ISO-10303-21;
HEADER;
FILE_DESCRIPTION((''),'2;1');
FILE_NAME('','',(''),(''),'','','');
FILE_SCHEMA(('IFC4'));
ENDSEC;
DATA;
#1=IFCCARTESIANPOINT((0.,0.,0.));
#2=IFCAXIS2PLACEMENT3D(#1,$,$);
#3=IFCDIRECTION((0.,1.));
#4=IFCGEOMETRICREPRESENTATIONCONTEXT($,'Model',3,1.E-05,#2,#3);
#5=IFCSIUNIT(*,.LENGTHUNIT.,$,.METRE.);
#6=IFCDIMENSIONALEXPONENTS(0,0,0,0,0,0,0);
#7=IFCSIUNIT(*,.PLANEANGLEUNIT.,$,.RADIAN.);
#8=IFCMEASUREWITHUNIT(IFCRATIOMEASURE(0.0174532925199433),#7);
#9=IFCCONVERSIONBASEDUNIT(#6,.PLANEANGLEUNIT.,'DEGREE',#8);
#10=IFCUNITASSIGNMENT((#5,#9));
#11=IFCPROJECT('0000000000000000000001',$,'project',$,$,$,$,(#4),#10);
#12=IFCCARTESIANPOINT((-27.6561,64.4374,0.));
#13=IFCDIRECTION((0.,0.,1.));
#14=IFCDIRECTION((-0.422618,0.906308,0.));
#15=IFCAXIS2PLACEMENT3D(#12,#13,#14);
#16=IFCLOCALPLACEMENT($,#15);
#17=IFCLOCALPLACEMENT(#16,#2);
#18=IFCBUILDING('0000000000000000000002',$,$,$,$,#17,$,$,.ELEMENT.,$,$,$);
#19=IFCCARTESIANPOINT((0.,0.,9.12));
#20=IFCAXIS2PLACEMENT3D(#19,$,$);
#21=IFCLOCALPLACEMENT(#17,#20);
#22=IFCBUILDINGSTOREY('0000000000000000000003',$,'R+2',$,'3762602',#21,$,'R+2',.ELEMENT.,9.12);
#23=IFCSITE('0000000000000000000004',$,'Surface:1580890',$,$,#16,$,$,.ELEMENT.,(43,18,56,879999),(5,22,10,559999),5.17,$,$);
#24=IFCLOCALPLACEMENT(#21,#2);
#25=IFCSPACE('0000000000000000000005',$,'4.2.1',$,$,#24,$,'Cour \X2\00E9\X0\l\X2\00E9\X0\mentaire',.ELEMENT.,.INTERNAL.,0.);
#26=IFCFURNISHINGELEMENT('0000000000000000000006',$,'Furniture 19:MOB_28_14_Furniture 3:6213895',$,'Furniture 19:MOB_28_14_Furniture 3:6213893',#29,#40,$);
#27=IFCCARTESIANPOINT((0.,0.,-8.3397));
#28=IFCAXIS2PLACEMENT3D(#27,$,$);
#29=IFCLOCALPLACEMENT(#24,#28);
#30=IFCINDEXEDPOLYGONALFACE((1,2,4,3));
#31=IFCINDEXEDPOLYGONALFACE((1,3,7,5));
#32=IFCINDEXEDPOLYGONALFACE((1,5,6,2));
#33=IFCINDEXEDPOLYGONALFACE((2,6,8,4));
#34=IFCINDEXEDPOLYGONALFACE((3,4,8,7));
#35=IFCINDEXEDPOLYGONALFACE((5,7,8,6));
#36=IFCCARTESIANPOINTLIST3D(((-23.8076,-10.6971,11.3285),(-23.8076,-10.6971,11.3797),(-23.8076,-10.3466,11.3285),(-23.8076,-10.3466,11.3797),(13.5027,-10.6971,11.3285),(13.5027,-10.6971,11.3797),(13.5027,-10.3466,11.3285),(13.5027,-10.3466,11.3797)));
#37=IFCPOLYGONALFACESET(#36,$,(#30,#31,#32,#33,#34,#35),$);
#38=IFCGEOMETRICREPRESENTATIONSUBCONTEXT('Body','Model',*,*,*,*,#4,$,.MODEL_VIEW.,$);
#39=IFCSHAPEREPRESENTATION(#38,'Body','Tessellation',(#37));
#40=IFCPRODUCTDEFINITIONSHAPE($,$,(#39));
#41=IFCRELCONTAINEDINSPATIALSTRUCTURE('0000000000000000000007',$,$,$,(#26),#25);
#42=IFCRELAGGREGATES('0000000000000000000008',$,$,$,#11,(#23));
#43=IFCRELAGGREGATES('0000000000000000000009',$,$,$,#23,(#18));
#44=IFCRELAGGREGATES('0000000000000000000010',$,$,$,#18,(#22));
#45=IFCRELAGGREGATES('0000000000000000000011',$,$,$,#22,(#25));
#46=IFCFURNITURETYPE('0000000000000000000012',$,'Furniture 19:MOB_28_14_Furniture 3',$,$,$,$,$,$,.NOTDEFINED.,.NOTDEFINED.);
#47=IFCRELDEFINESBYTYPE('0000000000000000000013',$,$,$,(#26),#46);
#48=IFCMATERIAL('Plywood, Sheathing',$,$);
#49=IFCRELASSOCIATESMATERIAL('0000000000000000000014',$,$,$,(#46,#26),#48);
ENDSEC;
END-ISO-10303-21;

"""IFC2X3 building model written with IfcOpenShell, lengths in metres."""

from ifc_helpers import new_model, entity, si_unit, converted_unit, direction, frame, origin, origin_2d_with_axis, place, context, subcontext, project, spatial, rectangle, extrude, source, transform, mapped, material, type_object, type_shapes, element, save


model = new_model("IFC2X3")

# Units and contexts
model_context = context("Model", 3, precision=1e-05, world=origin(), true_north=direction((0.0, 1.0)))
body_context = subcontext(model_context, "Body", "Model", "MODEL_VIEW")
ifc_project = project(units=[si_unit("LENGTHUNIT", "METRE"), converted_unit("PLANEANGLEUNIT", "DEGREE", entity("IfcRatioMeasure", 0.0174532925199433), si_unit("PLANEANGLEUNIT", "RADIAN"), dimensions=[0, 0, 0, 0, 0, 0, 0])], contexts=[model_context])

# Site, building, storey
site_placement = place(None, frame((-27.6561, 64.4374, 0.0), z_axis=(0.0, 0.0, 1.0), x_axis=(-0.422618, 0.906308, 0.0)))
site = spatial("IfcSite", under=ifc_project, at=site_placement, Name="Surface:1580890", CompositionType="ELEMENT", RefLatitude=(43, 18, 56, 879999), RefLongitude=(5, 22, 10, 559999), RefElevation=5.17)
building_placement = place(site_placement, origin())
building = spatial("IfcBuilding", under=site, at=building_placement, CompositionType="ELEMENT")
storey_placement = place(building_placement, frame((0.0, 0.0, 9.12)))
storey = spatial("IfcBuildingStorey", under=building, at=storey_placement, Name="R+2", ObjectType="3762602", LongName="R+2", CompositionType="ELEMENT", Elevation=9.12)

# Shared definitions
space_placement = place(storey_placement, origin())
space = spatial("IfcSpace", under=storey, at=space_placement, Name="4.2.1", LongName="Cour élémentaire", CompositionType="ELEMENT", InteriorOrExteriorSpace="INTERNAL", ElevationWithFlooring=0.0)

# Furnishing element
ifc_material_1 = material(Name="Plywood, Sheathing")
furniture_type = type_object("IfcFurnitureType", Name="Furniture 19:MOB_28_14_Furniture 3", material=ifc_material_1)
shared_shape = source(origin(), body_context, "Body", "SweptSolid", [
    extrude(rectangle(XDim=37.3104, YDim=0.3505, at=origin_2d_with_axis()), frame((-5.1524, -10.5218, 11.3285), z_axis=(0.0, 0.0, 1.0), x_axis=(-1.0, 0.0, 0.0)), (0.0, 0.0, 1.0), 0.0512),
])
type_shapes(furniture_type, [shared_shape])
furnishing_placement = place(space_placement, frame((0.0, 0.0, -8.3397)))
element("IfcFurnishingElement", 1, at=furnishing_placement, inside=space, type_object=furniture_type, material=ifc_material_1, Name="Furniture 19:MOB_28_14_Furniture 3:6213895", ObjectType="Furniture 19:MOB_28_14_Furniture 3:6213893", context=body_context, shape_type="MappedRepresentation", body=[
    mapped(shared_shape, transform((0.0, 0.0, 0.0), scale=1.0)),
])

save(model, "model.ifc")
